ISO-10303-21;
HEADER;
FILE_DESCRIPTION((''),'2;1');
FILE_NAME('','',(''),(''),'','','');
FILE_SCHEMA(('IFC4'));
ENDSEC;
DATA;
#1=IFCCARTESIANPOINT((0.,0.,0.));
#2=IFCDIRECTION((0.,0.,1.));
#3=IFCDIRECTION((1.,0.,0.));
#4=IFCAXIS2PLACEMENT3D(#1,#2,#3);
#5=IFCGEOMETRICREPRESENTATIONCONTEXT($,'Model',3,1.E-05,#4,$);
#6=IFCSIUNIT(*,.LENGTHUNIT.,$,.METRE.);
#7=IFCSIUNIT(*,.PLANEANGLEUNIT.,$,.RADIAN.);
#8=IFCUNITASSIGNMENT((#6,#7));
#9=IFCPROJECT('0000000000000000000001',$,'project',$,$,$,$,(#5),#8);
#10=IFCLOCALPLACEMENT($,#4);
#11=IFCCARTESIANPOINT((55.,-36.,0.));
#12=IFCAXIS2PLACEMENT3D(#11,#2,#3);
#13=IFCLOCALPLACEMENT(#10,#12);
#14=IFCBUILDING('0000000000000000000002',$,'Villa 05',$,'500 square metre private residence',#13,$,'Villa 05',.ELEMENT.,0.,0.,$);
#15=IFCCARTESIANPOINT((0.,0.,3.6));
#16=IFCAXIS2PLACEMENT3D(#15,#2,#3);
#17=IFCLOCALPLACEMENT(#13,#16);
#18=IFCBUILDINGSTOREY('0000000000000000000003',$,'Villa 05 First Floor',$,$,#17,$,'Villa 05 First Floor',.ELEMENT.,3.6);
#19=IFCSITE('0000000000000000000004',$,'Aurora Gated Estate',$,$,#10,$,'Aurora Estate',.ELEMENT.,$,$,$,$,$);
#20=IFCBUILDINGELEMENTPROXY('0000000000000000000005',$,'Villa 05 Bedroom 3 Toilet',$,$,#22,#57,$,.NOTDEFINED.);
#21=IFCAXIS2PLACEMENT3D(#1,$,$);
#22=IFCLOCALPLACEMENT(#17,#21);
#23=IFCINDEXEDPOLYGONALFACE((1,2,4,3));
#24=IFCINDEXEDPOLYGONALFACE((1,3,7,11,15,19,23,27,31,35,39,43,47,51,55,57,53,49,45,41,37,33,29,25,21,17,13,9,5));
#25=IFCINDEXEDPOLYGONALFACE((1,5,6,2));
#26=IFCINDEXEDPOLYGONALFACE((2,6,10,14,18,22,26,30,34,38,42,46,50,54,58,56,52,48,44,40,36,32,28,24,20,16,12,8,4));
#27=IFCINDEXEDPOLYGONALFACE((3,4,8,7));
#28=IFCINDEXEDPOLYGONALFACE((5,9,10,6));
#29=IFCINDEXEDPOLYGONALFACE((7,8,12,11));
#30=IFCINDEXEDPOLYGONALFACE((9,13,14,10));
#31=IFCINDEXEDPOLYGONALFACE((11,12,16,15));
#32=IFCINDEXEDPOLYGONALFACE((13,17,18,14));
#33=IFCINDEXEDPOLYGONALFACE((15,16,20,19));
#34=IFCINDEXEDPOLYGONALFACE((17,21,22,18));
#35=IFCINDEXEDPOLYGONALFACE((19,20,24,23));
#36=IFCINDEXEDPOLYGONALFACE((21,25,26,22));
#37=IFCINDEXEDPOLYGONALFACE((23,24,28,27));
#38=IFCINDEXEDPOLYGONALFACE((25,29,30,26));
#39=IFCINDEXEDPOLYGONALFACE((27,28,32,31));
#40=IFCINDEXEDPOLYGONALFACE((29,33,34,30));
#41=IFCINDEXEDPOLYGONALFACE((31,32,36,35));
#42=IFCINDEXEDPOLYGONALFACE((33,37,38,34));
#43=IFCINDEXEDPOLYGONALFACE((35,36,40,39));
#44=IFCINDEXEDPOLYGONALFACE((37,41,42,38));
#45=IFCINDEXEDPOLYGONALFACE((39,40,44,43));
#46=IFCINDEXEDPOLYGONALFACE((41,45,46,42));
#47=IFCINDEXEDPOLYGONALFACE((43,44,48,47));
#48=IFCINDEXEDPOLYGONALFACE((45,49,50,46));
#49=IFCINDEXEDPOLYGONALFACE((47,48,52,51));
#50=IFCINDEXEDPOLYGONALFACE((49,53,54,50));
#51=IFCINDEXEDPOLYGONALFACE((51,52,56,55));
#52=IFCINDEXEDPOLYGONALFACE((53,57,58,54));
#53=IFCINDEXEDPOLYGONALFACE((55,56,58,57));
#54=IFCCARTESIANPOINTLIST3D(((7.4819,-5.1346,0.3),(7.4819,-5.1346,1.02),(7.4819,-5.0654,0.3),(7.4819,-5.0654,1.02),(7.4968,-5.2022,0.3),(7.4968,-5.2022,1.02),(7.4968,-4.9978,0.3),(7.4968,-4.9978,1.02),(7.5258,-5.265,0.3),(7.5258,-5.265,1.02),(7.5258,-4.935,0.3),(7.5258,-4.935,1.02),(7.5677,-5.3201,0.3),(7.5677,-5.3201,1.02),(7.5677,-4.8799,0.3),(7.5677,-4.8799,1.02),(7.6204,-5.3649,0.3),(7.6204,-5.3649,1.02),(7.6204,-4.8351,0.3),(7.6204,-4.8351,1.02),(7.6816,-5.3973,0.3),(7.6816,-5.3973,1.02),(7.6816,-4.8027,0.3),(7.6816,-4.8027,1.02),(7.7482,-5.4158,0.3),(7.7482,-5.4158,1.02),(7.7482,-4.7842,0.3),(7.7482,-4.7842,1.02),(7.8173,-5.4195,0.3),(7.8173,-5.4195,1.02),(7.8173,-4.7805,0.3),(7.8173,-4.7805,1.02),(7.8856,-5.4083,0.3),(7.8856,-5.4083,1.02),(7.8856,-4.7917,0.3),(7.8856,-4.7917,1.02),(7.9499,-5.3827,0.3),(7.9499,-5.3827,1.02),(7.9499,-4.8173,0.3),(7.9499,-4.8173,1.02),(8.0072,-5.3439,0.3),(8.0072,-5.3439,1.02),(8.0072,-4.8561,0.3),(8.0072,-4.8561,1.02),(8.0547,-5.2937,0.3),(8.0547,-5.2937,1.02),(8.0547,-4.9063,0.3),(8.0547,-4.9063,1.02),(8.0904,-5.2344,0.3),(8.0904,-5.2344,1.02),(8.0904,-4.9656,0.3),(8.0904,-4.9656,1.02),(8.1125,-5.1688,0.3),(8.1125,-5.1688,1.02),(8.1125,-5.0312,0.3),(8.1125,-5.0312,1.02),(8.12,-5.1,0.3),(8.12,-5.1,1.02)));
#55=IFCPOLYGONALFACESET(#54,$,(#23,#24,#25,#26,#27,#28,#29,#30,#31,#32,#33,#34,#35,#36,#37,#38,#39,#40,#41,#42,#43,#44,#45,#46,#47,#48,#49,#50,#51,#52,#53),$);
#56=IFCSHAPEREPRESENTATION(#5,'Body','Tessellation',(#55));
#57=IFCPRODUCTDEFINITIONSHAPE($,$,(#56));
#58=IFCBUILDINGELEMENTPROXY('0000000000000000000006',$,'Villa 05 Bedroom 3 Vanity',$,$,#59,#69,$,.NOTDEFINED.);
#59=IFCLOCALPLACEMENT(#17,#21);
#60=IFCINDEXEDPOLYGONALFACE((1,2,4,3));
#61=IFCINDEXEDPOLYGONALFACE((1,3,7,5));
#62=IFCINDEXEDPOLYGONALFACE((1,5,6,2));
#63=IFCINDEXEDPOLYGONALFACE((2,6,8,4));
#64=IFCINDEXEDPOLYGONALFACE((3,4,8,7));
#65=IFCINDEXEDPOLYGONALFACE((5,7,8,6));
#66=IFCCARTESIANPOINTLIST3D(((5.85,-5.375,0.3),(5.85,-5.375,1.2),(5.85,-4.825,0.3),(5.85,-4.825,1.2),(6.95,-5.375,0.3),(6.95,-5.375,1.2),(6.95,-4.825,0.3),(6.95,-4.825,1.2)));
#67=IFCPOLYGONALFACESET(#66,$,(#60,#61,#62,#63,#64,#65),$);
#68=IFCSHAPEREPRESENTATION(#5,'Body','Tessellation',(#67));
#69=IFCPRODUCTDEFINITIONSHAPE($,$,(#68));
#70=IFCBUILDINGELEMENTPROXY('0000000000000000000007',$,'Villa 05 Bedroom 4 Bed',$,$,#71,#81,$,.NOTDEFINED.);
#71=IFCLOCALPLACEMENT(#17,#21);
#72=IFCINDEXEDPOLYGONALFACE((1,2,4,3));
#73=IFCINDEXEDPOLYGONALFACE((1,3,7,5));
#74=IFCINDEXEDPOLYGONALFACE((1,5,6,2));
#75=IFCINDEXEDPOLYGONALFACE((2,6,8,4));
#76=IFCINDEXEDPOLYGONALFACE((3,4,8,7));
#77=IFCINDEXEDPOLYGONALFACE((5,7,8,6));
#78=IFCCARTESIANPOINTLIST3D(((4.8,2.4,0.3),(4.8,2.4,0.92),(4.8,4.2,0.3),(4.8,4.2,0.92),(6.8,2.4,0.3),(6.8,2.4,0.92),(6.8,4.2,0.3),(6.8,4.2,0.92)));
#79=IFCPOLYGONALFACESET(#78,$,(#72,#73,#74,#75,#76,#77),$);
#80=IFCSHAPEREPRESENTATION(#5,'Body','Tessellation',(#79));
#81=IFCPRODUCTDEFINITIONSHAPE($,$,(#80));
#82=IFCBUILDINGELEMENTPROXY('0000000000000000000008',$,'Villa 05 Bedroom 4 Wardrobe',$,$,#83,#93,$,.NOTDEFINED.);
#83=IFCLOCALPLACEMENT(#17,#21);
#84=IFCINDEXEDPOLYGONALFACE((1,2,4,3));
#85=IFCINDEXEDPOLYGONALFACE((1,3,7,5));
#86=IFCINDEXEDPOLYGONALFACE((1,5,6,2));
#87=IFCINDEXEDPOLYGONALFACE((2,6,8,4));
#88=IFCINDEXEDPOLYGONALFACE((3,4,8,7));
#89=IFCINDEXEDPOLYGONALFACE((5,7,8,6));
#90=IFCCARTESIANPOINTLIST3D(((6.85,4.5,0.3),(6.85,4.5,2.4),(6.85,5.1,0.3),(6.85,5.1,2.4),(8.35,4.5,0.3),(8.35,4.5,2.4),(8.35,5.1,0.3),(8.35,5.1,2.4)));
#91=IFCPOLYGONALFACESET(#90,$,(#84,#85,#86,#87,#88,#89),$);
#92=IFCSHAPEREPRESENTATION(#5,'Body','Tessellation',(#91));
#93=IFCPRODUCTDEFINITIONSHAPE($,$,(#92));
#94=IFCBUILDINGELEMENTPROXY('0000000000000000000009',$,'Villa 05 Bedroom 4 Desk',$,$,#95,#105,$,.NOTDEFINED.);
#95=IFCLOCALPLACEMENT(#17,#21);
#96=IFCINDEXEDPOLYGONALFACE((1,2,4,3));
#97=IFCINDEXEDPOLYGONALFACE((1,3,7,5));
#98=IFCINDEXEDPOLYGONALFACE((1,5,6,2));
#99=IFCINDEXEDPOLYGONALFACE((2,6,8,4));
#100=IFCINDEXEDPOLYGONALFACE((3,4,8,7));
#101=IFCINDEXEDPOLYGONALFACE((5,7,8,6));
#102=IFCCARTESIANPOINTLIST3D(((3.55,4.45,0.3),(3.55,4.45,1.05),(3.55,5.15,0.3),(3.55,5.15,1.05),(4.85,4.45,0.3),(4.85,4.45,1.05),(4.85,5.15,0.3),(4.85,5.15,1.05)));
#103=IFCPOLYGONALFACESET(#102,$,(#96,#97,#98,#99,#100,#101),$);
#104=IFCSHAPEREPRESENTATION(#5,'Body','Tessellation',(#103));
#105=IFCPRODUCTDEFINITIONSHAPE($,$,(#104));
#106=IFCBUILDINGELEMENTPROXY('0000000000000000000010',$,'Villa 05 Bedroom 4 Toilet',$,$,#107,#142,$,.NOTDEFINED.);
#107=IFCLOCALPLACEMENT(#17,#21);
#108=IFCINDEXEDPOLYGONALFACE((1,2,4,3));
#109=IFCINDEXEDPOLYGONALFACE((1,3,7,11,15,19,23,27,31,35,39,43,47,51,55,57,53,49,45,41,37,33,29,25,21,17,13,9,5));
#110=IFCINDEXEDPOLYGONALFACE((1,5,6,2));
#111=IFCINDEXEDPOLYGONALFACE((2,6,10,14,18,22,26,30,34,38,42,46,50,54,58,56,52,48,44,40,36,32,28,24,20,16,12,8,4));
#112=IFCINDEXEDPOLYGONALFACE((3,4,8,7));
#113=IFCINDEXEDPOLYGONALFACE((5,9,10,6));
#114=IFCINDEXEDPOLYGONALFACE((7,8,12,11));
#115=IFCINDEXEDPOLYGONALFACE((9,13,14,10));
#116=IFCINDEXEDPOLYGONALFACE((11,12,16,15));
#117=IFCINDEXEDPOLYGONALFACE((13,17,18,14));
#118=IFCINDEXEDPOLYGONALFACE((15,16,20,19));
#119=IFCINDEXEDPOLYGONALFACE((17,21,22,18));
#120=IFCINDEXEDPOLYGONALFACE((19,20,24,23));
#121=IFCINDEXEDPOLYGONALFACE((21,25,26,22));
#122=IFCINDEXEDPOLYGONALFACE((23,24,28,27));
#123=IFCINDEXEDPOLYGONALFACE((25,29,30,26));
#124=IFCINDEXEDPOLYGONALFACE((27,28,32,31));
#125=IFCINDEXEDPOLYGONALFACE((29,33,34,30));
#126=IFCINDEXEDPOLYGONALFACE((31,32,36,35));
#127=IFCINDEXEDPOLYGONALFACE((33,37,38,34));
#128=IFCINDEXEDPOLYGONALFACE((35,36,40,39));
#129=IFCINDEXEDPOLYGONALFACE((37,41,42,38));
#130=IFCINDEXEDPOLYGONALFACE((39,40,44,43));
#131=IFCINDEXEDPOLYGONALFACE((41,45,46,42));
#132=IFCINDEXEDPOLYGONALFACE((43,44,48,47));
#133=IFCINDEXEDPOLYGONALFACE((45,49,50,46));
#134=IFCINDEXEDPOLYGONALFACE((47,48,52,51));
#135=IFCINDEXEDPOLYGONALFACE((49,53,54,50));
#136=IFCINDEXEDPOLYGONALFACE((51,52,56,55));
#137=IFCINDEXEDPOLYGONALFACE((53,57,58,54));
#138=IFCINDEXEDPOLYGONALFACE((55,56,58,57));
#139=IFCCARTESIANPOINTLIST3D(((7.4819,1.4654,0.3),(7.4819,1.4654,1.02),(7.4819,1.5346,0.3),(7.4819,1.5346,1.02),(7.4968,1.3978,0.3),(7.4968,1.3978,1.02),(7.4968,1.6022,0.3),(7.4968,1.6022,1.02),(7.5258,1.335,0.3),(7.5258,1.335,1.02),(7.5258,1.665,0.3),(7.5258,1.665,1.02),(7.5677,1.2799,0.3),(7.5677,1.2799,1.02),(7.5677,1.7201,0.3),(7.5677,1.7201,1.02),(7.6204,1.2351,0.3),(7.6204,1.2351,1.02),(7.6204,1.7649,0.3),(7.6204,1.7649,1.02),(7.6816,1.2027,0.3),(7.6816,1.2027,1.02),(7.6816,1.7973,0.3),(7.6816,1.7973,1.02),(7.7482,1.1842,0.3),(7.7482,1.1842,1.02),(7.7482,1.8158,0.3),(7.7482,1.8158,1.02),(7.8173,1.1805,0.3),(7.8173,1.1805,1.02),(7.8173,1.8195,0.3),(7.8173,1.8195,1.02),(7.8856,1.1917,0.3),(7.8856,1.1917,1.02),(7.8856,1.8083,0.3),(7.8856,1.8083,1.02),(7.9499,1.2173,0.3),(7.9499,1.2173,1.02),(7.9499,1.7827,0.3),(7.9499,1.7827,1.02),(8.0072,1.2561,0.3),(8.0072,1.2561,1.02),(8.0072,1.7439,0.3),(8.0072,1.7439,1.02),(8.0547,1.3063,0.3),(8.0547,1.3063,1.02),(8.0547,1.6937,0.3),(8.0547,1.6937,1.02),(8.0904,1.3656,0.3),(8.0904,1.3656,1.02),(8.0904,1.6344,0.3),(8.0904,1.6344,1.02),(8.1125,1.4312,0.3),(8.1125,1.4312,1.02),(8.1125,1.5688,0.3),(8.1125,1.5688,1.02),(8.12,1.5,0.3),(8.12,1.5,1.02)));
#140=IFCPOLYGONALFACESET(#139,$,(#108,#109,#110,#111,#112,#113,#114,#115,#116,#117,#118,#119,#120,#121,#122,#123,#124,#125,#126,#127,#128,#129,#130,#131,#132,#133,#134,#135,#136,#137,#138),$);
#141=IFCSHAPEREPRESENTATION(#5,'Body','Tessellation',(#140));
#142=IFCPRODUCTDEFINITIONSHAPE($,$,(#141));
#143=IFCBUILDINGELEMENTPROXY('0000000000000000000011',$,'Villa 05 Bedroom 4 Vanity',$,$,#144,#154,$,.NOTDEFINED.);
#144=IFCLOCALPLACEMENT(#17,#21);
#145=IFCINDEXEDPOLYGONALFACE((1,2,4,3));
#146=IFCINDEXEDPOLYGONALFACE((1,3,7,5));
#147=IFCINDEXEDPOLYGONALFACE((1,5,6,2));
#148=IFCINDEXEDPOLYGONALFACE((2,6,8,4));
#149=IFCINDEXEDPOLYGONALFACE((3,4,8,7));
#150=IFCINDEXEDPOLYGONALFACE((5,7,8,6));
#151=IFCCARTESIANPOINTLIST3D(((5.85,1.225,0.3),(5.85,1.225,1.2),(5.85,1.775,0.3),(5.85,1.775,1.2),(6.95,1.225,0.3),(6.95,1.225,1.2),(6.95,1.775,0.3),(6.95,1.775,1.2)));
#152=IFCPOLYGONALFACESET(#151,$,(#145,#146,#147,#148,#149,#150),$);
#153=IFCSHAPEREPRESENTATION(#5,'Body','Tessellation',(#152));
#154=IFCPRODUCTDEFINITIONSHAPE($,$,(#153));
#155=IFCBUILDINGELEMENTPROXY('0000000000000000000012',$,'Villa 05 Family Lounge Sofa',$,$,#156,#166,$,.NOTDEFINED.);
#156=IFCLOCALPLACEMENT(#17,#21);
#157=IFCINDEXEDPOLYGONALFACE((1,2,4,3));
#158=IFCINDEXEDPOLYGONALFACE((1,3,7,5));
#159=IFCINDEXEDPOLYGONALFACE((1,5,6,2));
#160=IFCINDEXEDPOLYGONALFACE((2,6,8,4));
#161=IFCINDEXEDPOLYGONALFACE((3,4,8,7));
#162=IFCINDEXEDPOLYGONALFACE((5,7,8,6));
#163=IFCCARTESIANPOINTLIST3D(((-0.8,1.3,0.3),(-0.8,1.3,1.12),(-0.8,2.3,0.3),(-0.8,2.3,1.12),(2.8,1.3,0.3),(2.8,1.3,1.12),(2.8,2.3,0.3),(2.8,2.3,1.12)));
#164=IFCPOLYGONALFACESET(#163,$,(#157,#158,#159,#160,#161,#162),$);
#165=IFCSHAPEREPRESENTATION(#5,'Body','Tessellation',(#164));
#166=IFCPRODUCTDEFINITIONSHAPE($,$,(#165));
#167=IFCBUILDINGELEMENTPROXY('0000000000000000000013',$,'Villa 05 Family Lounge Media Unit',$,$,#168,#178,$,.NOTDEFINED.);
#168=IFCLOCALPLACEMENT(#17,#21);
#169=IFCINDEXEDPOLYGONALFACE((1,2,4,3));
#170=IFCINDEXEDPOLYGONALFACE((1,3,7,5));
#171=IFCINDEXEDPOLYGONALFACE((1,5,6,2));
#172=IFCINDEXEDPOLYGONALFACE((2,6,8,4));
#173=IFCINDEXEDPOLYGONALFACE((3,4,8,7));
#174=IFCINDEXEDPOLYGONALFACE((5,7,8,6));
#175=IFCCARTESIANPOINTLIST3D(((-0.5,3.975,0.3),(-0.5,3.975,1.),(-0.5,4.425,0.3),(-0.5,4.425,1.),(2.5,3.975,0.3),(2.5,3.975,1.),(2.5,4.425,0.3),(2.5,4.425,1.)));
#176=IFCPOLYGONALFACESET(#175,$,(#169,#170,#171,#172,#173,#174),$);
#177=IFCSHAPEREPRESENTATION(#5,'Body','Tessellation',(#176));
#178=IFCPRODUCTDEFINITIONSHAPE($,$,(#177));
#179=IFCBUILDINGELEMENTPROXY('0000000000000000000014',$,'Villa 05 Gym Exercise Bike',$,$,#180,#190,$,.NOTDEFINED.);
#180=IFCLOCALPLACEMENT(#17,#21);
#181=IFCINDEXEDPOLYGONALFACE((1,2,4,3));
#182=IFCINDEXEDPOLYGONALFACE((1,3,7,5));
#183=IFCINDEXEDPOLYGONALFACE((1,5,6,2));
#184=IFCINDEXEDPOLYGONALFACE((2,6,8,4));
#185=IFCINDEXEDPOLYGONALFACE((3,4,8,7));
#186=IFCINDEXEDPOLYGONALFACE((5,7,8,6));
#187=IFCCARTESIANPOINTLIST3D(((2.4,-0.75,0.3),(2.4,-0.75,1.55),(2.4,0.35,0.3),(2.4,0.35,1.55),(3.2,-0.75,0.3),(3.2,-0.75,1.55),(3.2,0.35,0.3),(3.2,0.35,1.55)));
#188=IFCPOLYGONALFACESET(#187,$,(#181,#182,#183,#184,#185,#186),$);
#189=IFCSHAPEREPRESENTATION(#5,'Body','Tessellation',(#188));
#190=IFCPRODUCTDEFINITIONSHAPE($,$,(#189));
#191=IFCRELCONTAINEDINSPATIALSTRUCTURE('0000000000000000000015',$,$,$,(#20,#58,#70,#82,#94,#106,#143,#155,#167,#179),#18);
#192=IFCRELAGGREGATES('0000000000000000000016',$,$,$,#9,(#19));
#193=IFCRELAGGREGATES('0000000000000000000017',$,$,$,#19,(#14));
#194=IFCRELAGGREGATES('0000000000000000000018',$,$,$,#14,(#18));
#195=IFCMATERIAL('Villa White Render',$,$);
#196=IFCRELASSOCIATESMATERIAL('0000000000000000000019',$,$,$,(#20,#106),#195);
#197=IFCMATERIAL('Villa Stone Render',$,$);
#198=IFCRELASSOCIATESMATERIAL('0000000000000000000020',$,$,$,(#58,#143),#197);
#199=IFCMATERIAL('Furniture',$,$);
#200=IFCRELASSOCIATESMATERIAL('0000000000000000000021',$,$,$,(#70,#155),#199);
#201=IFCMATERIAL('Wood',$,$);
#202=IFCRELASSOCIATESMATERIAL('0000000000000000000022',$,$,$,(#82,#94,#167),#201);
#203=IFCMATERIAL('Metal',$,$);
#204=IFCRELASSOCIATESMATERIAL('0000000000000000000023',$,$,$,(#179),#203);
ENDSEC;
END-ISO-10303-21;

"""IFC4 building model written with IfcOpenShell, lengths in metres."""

from ifc_helpers import new_model, si_unit, frame, origin_with_axes, origin_2d_with_axis, place, context, project, spatial, rectangle, circle, extrude, material, element, save


model = new_model("IFC4")

# Units and contexts
model_context = context("Model", 3, precision=1e-05, world=origin_with_axes())
ifc_project = project(units=[si_unit("LENGTHUNIT", "METRE"), si_unit("PLANEANGLEUNIT", "RADIAN")], contexts=[model_context])

# Site, building, storey
site_placement = place(None, origin_with_axes())
site = spatial("IfcSite", under=ifc_project, at=site_placement, Name="Aurora Gated Estate", LongName="Aurora Estate", CompositionType="ELEMENT")
building_placement = place(site_placement, frame((55.0, -36.0, 0.0), z_axis=(0.0, 0.0, 1.0), x_axis=(1.0, 0.0, 0.0)))
building = spatial("IfcBuilding", under=site, at=building_placement, Name="Villa 05", ObjectType="500 square metre private residence", LongName="Villa 05", CompositionType="ELEMENT", ElevationOfRefHeight=0.0, ElevationOfTerrain=0.0)
storey_placement = place(building_placement, frame((0.0, 0.0, 3.6), z_axis=(0.0, 0.0, 1.0), x_axis=(1.0, 0.0, 0.0)))
storey = spatial("IfcBuildingStorey", under=building, at=storey_placement, Name="Villa 05 First Floor", LongName="Villa 05 First Floor", CompositionType="ELEMENT", Elevation=3.6)

# Building element proxies
ifc_material_1 = material(Name="Wood")
ifc_material_2 = material(Name="Villa White Render")
ifc_material_3 = material(Name="Villa Stone Render")
ifc_material_4 = material(Name="Furniture")
proxy_1_placement = place(storey_placement, frame((7.8, -5.1, 0.3), z_axis=(0.0, 0.0, 1.0), x_axis=(1.0, 0.0, 0.0)))
element("IfcBuildingElementProxy", 1, at=proxy_1_placement, inside=storey, material=ifc_material_2, Name="Villa 05 Bedroom 3 Toilet", PredefinedType="NOTDEFINED", context=model_context, shape_type="SweptSolid", body=[
    extrude(circle(Radius=0.32, at=origin_2d_with_axis()), origin_with_axes(), (0.0, 0.0, 1.0), 0.72),
])
proxy_2_placement = place(storey_placement, frame((6.4, -5.1, 0.3), z_axis=(0.0, 0.0, 1.0), x_axis=(1.0, 0.0, 0.0)))
element("IfcBuildingElementProxy", 2, at=proxy_2_placement, inside=storey, material=ifc_material_3, Name="Villa 05 Bedroom 3 Vanity", PredefinedType="NOTDEFINED", context=model_context, shape_type="SweptSolid", body=[
    extrude(rectangle(XDim=1.1, YDim=0.55, at=origin_2d_with_axis()), origin_with_axes(), (0.0, 0.0, 1.0), 0.9),
])
proxy_3_placement = place(storey_placement, frame((5.8, 3.3, 0.3), z_axis=(0.0, 0.0, 1.0), x_axis=(1.0, 0.0, 0.0)))
element("IfcBuildingElementProxy", 3, at=proxy_3_placement, inside=storey, material=ifc_material_4, Name="Villa 05 Bedroom 4 Bed", PredefinedType="NOTDEFINED", context=model_context, shape_type="SweptSolid", body=[
    extrude(rectangle(XDim=2.0, YDim=1.8, at=origin_2d_with_axis()), origin_with_axes(), (0.0, 0.0, 1.0), 0.62),
])
proxy_4_placement = place(storey_placement, frame((7.6, 4.8, 0.3), z_axis=(0.0, 0.0, 1.0), x_axis=(1.0, 0.0, 0.0)))
element("IfcBuildingElementProxy", 4, at=proxy_4_placement, inside=storey, material=ifc_material_1, Name="Villa 05 Bedroom 4 Wardrobe", PredefinedType="NOTDEFINED", context=model_context, shape_type="SweptSolid", body=[
    extrude(rectangle(XDim=1.5, YDim=0.6, at=origin_2d_with_axis()), origin_with_axes(), (0.0, 0.0, 1.0), 2.1),
])
proxy_5_placement = place(storey_placement, frame((4.2, 4.8, 0.3), z_axis=(0.0, 0.0, 1.0), x_axis=(1.0, 0.0, 0.0)))
element("IfcBuildingElementProxy", 5, at=proxy_5_placement, inside=storey, material=ifc_material_1, Name="Villa 05 Bedroom 4 Desk", PredefinedType="NOTDEFINED", context=model_context, shape_type="SweptSolid", body=[
    extrude(rectangle(XDim=1.3, YDim=0.7, at=origin_2d_with_axis()), origin_with_axes(), (0.0, 0.0, 1.0), 0.75),
])
proxy_6_placement = place(storey_placement, frame((7.8, 1.5, 0.3), z_axis=(0.0, 0.0, 1.0), x_axis=(1.0, 0.0, 0.0)))
element("IfcBuildingElementProxy", 6, at=proxy_6_placement, inside=storey, material=ifc_material_2, Name="Villa 05 Bedroom 4 Toilet", PredefinedType="NOTDEFINED", context=model_context, shape_type="SweptSolid", body=[
    extrude(circle(Radius=0.32, at=origin_2d_with_axis()), origin_with_axes(), (0.0, 0.0, 1.0), 0.72),
])
proxy_7_placement = place(storey_placement, frame((6.4, 1.5, 0.3), z_axis=(0.0, 0.0, 1.0), x_axis=(1.0, 0.0, 0.0)))
element("IfcBuildingElementProxy", 7, at=proxy_7_placement, inside=storey, material=ifc_material_3, Name="Villa 05 Bedroom 4 Vanity", PredefinedType="NOTDEFINED", context=model_context, shape_type="SweptSolid", body=[
    extrude(rectangle(XDim=1.1, YDim=0.55, at=origin_2d_with_axis()), origin_with_axes(), (0.0, 0.0, 1.0), 0.9),
])
proxy_8_placement = place(storey_placement, frame((1.0, 1.8, 0.3), z_axis=(0.0, 0.0, 1.0), x_axis=(1.0, 0.0, 0.0)))
element("IfcBuildingElementProxy", 8, at=proxy_8_placement, inside=storey, material=ifc_material_4, Name="Villa 05 Family Lounge Sofa", PredefinedType="NOTDEFINED", context=model_context, shape_type="SweptSolid", body=[
    extrude(rectangle(XDim=3.6, YDim=1.0, at=origin_2d_with_axis()), origin_with_axes(), (0.0, 0.0, 1.0), 0.82),
])
proxy_9_placement = place(storey_placement, frame((1.0, 4.2, 0.3), z_axis=(0.0, 0.0, 1.0), x_axis=(1.0, 0.0, 0.0)))
element("IfcBuildingElementProxy", 9, at=proxy_9_placement, inside=storey, material=ifc_material_1, Name="Villa 05 Family Lounge Media Unit", PredefinedType="NOTDEFINED", context=model_context, shape_type="SweptSolid", body=[
    extrude(rectangle(XDim=3.0, YDim=0.45, at=origin_2d_with_axis()), origin_with_axes(), (0.0, 0.0, 1.0), 0.7),
])
ifc_material_5 = material(Name="Metal")
proxy_10_placement = place(storey_placement, frame((2.8, -0.2, 0.3), z_axis=(0.0, 0.0, 1.0), x_axis=(1.0, 0.0, 0.0)))
element("IfcBuildingElementProxy", 10, at=proxy_10_placement, inside=storey, material=ifc_material_5, Name="Villa 05 Gym Exercise Bike", PredefinedType="NOTDEFINED", context=model_context, shape_type="SweptSolid", body=[
    extrude(rectangle(XDim=0.8, YDim=1.1, at=origin_2d_with_axis()), origin_with_axes(), (0.0, 0.0, 1.0), 1.25),
])

save(model, "model.ifc")
